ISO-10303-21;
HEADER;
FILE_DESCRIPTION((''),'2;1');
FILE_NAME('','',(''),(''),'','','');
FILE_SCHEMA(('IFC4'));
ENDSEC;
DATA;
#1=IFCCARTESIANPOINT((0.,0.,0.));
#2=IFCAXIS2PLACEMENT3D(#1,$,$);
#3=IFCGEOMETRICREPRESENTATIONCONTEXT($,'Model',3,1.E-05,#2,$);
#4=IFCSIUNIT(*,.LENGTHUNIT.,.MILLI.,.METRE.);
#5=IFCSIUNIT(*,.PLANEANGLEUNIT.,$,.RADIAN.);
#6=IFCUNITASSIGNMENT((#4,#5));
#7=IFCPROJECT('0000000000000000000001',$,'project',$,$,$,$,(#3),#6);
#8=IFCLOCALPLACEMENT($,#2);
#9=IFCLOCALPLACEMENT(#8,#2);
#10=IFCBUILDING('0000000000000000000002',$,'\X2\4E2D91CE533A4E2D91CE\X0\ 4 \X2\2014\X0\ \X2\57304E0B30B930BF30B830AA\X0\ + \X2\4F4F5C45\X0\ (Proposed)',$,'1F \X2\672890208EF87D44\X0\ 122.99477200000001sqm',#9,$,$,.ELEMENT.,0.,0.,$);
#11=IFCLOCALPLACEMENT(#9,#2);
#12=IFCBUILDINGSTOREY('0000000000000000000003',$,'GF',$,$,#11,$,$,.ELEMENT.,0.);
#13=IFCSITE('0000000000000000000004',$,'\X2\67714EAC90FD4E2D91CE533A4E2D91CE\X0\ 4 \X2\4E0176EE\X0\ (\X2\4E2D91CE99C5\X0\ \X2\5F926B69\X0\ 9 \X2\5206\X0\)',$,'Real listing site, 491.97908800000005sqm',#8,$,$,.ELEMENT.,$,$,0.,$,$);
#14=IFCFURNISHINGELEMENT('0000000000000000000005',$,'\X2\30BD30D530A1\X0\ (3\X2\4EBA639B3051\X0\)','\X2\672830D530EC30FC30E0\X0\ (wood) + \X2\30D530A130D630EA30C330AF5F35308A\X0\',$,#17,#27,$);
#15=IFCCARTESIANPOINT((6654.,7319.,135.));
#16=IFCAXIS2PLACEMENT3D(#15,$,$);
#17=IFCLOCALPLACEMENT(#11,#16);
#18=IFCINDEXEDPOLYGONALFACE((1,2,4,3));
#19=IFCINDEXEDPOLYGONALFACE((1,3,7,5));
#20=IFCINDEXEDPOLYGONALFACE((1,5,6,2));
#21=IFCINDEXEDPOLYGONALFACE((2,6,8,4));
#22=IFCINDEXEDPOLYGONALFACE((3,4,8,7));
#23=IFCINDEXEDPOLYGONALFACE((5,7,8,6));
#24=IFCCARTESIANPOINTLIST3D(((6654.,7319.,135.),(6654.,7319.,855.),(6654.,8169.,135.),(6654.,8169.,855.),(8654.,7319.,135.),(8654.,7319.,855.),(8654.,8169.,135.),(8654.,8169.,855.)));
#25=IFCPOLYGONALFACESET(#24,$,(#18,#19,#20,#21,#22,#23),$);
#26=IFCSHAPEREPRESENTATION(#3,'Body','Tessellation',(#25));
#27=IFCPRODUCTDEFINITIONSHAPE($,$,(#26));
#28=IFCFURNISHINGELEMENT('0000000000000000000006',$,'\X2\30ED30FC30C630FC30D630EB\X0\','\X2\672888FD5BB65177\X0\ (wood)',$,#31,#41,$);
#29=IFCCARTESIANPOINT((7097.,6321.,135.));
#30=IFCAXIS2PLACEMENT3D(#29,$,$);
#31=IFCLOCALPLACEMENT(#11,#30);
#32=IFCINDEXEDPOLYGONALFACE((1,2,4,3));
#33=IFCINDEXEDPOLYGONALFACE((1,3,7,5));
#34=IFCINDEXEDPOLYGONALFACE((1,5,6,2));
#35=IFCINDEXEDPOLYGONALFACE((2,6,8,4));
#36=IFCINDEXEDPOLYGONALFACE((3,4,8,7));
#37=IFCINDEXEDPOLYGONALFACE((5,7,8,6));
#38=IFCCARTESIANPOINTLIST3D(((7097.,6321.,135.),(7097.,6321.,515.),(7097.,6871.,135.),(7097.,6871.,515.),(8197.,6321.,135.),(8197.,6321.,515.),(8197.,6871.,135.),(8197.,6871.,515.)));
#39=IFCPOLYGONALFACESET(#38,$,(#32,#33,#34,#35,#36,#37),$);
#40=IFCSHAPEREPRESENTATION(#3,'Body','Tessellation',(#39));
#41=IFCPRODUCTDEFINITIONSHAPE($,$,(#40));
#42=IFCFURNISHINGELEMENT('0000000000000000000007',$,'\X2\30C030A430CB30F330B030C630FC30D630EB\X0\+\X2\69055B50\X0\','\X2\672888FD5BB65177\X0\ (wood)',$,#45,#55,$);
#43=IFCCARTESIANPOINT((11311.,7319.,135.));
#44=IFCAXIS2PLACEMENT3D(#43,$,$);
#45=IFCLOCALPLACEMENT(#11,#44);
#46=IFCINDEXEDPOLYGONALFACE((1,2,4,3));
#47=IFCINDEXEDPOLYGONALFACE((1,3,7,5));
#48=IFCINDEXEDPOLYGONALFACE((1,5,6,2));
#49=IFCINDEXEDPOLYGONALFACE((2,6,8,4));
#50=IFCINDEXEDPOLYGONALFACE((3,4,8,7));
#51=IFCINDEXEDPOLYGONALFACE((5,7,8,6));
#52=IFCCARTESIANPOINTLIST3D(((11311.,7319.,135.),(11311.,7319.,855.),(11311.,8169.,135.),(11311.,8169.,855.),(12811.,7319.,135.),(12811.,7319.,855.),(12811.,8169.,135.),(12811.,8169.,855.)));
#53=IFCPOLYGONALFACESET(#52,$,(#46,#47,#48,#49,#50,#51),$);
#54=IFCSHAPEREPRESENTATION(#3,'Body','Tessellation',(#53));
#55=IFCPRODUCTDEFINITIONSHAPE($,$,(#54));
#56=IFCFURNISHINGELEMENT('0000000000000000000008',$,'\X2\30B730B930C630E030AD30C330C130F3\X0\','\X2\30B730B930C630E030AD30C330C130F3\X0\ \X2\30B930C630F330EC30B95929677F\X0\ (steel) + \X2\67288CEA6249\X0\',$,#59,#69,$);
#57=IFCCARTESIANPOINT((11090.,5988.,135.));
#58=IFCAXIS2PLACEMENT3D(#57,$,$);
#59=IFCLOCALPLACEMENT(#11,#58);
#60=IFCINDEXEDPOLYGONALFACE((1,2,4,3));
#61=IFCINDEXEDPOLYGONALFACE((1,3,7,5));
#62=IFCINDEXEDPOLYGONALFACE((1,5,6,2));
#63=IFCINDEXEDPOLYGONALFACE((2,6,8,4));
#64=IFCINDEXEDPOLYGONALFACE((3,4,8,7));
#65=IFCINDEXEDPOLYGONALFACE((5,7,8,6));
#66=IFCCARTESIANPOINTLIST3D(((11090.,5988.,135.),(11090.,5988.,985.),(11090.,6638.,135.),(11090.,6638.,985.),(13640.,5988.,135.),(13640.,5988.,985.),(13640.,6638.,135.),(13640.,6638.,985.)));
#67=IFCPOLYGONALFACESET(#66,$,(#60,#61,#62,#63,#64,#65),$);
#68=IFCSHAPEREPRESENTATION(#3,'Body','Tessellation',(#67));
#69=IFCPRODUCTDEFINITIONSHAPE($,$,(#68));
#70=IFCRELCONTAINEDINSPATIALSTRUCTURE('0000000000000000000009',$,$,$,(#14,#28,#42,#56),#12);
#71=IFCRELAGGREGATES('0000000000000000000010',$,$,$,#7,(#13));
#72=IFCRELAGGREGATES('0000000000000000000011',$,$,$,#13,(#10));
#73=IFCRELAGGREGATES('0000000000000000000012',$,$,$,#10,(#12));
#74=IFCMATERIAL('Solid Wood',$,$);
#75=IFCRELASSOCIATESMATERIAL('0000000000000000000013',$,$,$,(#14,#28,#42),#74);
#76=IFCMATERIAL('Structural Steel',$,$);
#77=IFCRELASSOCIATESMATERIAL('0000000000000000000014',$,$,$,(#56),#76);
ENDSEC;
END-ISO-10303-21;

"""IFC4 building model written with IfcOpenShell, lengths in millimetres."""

from ifc_helpers import new_model, si_unit, frame, frame_2d, origin, place, context, project, spatial, rectangle, extrude, material, element, save


model = new_model("IFC4")

# Units and contexts
model_context = context("Model", 3, precision=1e-05, world=origin())
ifc_project = project(units=[si_unit("LENGTHUNIT", "METRE", prefix="MILLI"), si_unit("PLANEANGLEUNIT", "RADIAN")], contexts=[model_context])

# Site, building, storey
site_placement = place(None, origin())
site = spatial("IfcSite", under=ifc_project, at=site_placement, Name="東京都中野区中野 4 丁目 (中野駅 徒歩 9 分)", ObjectType="Real listing site, 491.97908800000005sqm", CompositionType="ELEMENT", RefElevation=0.0)
building_placement = place(site_placement, origin())
building = spatial("IfcBuilding", under=site, at=building_placement, Name="中野区中野 4 — 地下スタジオ + 住居 (Proposed)", ObjectType="1F 木造軸組 122.99477200000001sqm", CompositionType="ELEMENT", ElevationOfRefHeight=0.0, ElevationOfTerrain=0.0)
storey_placement = place(building_placement, origin())
storey = spatial("IfcBuildingStorey", under=building, at=storey_placement, Name="GF", CompositionType="ELEMENT", Elevation=0.0)

# Shared definitions
ifc_material_1 = material(Name="Solid Wood")

# Shared definitions
ifc_material_2 = material(Name="Structural Steel")

# Furnishing elements
furnishing_1_placement = place(storey_placement, frame((6654.0, 7319.0, 135.0)))
element("IfcFurnishingElement", 1, at=furnishing_1_placement, inside=storey, material=ifc_material_1, Name="ソファ (3人掛け)", Description="木フレーム (wood) + ファブリック張り", context=model_context, shape_type="SweptSolid", body=[
    extrude(rectangle(XDim=2000.0, YDim=850.0, at=frame_2d((1000.0, 425.0))), frame((6654.0, 7319.0, 135.0)), (0.0, 0.0, 1.0), 720.0),
])
furnishing_2_placement = place(storey_placement, frame((7097.0, 6321.0, 135.0)))
element("IfcFurnishingElement", 2, at=furnishing_2_placement, inside=storey, material=ifc_material_1, Name="ローテーブル", Description="木製家具 (wood)", context=model_context, shape_type="SweptSolid", body=[
    extrude(rectangle(XDim=1100.0, YDim=550.0, at=frame_2d((550.0, 275.0))), frame((7097.0, 6321.0, 135.0)), (0.0, 0.0, 1.0), 380.0),
])
furnishing_3_placement = place(storey_placement, frame((11311.0, 7319.0, 135.0)))
element("IfcFurnishingElement", 3, at=furnishing_3_placement, inside=storey, material=ifc_material_1, Name="ダイニングテーブル+椅子", Description="木製家具 (wood)", context=model_context, shape_type="SweptSolid", body=[
    extrude(rectangle(XDim=1500.0, YDim=850.0, at=frame_2d((750.0, 425.0))), frame((11311.0, 7319.0, 135.0)), (0.0, 0.0, 1.0), 720.0),
])
furnishing_4_placement = place(storey_placement, frame((11090.0, 5988.0, 135.0)))
element("IfcFurnishingElement", 4, at=furnishing_4_placement, inside=storey, material=ifc_material_2, Name="システムキッチン", Description="システムキッチン ステンレス天板 (steel) + 木質扉", context=model_context, shape_type="SweptSolid", body=[
    extrude(rectangle(XDim=2550.0, YDim=650.0, at=frame_2d((1275.0, 325.0))), frame((11090.0, 5988.0, 135.0)), (0.0, 0.0, 1.0), 850.0),
])

save(model, "model.ifc")
